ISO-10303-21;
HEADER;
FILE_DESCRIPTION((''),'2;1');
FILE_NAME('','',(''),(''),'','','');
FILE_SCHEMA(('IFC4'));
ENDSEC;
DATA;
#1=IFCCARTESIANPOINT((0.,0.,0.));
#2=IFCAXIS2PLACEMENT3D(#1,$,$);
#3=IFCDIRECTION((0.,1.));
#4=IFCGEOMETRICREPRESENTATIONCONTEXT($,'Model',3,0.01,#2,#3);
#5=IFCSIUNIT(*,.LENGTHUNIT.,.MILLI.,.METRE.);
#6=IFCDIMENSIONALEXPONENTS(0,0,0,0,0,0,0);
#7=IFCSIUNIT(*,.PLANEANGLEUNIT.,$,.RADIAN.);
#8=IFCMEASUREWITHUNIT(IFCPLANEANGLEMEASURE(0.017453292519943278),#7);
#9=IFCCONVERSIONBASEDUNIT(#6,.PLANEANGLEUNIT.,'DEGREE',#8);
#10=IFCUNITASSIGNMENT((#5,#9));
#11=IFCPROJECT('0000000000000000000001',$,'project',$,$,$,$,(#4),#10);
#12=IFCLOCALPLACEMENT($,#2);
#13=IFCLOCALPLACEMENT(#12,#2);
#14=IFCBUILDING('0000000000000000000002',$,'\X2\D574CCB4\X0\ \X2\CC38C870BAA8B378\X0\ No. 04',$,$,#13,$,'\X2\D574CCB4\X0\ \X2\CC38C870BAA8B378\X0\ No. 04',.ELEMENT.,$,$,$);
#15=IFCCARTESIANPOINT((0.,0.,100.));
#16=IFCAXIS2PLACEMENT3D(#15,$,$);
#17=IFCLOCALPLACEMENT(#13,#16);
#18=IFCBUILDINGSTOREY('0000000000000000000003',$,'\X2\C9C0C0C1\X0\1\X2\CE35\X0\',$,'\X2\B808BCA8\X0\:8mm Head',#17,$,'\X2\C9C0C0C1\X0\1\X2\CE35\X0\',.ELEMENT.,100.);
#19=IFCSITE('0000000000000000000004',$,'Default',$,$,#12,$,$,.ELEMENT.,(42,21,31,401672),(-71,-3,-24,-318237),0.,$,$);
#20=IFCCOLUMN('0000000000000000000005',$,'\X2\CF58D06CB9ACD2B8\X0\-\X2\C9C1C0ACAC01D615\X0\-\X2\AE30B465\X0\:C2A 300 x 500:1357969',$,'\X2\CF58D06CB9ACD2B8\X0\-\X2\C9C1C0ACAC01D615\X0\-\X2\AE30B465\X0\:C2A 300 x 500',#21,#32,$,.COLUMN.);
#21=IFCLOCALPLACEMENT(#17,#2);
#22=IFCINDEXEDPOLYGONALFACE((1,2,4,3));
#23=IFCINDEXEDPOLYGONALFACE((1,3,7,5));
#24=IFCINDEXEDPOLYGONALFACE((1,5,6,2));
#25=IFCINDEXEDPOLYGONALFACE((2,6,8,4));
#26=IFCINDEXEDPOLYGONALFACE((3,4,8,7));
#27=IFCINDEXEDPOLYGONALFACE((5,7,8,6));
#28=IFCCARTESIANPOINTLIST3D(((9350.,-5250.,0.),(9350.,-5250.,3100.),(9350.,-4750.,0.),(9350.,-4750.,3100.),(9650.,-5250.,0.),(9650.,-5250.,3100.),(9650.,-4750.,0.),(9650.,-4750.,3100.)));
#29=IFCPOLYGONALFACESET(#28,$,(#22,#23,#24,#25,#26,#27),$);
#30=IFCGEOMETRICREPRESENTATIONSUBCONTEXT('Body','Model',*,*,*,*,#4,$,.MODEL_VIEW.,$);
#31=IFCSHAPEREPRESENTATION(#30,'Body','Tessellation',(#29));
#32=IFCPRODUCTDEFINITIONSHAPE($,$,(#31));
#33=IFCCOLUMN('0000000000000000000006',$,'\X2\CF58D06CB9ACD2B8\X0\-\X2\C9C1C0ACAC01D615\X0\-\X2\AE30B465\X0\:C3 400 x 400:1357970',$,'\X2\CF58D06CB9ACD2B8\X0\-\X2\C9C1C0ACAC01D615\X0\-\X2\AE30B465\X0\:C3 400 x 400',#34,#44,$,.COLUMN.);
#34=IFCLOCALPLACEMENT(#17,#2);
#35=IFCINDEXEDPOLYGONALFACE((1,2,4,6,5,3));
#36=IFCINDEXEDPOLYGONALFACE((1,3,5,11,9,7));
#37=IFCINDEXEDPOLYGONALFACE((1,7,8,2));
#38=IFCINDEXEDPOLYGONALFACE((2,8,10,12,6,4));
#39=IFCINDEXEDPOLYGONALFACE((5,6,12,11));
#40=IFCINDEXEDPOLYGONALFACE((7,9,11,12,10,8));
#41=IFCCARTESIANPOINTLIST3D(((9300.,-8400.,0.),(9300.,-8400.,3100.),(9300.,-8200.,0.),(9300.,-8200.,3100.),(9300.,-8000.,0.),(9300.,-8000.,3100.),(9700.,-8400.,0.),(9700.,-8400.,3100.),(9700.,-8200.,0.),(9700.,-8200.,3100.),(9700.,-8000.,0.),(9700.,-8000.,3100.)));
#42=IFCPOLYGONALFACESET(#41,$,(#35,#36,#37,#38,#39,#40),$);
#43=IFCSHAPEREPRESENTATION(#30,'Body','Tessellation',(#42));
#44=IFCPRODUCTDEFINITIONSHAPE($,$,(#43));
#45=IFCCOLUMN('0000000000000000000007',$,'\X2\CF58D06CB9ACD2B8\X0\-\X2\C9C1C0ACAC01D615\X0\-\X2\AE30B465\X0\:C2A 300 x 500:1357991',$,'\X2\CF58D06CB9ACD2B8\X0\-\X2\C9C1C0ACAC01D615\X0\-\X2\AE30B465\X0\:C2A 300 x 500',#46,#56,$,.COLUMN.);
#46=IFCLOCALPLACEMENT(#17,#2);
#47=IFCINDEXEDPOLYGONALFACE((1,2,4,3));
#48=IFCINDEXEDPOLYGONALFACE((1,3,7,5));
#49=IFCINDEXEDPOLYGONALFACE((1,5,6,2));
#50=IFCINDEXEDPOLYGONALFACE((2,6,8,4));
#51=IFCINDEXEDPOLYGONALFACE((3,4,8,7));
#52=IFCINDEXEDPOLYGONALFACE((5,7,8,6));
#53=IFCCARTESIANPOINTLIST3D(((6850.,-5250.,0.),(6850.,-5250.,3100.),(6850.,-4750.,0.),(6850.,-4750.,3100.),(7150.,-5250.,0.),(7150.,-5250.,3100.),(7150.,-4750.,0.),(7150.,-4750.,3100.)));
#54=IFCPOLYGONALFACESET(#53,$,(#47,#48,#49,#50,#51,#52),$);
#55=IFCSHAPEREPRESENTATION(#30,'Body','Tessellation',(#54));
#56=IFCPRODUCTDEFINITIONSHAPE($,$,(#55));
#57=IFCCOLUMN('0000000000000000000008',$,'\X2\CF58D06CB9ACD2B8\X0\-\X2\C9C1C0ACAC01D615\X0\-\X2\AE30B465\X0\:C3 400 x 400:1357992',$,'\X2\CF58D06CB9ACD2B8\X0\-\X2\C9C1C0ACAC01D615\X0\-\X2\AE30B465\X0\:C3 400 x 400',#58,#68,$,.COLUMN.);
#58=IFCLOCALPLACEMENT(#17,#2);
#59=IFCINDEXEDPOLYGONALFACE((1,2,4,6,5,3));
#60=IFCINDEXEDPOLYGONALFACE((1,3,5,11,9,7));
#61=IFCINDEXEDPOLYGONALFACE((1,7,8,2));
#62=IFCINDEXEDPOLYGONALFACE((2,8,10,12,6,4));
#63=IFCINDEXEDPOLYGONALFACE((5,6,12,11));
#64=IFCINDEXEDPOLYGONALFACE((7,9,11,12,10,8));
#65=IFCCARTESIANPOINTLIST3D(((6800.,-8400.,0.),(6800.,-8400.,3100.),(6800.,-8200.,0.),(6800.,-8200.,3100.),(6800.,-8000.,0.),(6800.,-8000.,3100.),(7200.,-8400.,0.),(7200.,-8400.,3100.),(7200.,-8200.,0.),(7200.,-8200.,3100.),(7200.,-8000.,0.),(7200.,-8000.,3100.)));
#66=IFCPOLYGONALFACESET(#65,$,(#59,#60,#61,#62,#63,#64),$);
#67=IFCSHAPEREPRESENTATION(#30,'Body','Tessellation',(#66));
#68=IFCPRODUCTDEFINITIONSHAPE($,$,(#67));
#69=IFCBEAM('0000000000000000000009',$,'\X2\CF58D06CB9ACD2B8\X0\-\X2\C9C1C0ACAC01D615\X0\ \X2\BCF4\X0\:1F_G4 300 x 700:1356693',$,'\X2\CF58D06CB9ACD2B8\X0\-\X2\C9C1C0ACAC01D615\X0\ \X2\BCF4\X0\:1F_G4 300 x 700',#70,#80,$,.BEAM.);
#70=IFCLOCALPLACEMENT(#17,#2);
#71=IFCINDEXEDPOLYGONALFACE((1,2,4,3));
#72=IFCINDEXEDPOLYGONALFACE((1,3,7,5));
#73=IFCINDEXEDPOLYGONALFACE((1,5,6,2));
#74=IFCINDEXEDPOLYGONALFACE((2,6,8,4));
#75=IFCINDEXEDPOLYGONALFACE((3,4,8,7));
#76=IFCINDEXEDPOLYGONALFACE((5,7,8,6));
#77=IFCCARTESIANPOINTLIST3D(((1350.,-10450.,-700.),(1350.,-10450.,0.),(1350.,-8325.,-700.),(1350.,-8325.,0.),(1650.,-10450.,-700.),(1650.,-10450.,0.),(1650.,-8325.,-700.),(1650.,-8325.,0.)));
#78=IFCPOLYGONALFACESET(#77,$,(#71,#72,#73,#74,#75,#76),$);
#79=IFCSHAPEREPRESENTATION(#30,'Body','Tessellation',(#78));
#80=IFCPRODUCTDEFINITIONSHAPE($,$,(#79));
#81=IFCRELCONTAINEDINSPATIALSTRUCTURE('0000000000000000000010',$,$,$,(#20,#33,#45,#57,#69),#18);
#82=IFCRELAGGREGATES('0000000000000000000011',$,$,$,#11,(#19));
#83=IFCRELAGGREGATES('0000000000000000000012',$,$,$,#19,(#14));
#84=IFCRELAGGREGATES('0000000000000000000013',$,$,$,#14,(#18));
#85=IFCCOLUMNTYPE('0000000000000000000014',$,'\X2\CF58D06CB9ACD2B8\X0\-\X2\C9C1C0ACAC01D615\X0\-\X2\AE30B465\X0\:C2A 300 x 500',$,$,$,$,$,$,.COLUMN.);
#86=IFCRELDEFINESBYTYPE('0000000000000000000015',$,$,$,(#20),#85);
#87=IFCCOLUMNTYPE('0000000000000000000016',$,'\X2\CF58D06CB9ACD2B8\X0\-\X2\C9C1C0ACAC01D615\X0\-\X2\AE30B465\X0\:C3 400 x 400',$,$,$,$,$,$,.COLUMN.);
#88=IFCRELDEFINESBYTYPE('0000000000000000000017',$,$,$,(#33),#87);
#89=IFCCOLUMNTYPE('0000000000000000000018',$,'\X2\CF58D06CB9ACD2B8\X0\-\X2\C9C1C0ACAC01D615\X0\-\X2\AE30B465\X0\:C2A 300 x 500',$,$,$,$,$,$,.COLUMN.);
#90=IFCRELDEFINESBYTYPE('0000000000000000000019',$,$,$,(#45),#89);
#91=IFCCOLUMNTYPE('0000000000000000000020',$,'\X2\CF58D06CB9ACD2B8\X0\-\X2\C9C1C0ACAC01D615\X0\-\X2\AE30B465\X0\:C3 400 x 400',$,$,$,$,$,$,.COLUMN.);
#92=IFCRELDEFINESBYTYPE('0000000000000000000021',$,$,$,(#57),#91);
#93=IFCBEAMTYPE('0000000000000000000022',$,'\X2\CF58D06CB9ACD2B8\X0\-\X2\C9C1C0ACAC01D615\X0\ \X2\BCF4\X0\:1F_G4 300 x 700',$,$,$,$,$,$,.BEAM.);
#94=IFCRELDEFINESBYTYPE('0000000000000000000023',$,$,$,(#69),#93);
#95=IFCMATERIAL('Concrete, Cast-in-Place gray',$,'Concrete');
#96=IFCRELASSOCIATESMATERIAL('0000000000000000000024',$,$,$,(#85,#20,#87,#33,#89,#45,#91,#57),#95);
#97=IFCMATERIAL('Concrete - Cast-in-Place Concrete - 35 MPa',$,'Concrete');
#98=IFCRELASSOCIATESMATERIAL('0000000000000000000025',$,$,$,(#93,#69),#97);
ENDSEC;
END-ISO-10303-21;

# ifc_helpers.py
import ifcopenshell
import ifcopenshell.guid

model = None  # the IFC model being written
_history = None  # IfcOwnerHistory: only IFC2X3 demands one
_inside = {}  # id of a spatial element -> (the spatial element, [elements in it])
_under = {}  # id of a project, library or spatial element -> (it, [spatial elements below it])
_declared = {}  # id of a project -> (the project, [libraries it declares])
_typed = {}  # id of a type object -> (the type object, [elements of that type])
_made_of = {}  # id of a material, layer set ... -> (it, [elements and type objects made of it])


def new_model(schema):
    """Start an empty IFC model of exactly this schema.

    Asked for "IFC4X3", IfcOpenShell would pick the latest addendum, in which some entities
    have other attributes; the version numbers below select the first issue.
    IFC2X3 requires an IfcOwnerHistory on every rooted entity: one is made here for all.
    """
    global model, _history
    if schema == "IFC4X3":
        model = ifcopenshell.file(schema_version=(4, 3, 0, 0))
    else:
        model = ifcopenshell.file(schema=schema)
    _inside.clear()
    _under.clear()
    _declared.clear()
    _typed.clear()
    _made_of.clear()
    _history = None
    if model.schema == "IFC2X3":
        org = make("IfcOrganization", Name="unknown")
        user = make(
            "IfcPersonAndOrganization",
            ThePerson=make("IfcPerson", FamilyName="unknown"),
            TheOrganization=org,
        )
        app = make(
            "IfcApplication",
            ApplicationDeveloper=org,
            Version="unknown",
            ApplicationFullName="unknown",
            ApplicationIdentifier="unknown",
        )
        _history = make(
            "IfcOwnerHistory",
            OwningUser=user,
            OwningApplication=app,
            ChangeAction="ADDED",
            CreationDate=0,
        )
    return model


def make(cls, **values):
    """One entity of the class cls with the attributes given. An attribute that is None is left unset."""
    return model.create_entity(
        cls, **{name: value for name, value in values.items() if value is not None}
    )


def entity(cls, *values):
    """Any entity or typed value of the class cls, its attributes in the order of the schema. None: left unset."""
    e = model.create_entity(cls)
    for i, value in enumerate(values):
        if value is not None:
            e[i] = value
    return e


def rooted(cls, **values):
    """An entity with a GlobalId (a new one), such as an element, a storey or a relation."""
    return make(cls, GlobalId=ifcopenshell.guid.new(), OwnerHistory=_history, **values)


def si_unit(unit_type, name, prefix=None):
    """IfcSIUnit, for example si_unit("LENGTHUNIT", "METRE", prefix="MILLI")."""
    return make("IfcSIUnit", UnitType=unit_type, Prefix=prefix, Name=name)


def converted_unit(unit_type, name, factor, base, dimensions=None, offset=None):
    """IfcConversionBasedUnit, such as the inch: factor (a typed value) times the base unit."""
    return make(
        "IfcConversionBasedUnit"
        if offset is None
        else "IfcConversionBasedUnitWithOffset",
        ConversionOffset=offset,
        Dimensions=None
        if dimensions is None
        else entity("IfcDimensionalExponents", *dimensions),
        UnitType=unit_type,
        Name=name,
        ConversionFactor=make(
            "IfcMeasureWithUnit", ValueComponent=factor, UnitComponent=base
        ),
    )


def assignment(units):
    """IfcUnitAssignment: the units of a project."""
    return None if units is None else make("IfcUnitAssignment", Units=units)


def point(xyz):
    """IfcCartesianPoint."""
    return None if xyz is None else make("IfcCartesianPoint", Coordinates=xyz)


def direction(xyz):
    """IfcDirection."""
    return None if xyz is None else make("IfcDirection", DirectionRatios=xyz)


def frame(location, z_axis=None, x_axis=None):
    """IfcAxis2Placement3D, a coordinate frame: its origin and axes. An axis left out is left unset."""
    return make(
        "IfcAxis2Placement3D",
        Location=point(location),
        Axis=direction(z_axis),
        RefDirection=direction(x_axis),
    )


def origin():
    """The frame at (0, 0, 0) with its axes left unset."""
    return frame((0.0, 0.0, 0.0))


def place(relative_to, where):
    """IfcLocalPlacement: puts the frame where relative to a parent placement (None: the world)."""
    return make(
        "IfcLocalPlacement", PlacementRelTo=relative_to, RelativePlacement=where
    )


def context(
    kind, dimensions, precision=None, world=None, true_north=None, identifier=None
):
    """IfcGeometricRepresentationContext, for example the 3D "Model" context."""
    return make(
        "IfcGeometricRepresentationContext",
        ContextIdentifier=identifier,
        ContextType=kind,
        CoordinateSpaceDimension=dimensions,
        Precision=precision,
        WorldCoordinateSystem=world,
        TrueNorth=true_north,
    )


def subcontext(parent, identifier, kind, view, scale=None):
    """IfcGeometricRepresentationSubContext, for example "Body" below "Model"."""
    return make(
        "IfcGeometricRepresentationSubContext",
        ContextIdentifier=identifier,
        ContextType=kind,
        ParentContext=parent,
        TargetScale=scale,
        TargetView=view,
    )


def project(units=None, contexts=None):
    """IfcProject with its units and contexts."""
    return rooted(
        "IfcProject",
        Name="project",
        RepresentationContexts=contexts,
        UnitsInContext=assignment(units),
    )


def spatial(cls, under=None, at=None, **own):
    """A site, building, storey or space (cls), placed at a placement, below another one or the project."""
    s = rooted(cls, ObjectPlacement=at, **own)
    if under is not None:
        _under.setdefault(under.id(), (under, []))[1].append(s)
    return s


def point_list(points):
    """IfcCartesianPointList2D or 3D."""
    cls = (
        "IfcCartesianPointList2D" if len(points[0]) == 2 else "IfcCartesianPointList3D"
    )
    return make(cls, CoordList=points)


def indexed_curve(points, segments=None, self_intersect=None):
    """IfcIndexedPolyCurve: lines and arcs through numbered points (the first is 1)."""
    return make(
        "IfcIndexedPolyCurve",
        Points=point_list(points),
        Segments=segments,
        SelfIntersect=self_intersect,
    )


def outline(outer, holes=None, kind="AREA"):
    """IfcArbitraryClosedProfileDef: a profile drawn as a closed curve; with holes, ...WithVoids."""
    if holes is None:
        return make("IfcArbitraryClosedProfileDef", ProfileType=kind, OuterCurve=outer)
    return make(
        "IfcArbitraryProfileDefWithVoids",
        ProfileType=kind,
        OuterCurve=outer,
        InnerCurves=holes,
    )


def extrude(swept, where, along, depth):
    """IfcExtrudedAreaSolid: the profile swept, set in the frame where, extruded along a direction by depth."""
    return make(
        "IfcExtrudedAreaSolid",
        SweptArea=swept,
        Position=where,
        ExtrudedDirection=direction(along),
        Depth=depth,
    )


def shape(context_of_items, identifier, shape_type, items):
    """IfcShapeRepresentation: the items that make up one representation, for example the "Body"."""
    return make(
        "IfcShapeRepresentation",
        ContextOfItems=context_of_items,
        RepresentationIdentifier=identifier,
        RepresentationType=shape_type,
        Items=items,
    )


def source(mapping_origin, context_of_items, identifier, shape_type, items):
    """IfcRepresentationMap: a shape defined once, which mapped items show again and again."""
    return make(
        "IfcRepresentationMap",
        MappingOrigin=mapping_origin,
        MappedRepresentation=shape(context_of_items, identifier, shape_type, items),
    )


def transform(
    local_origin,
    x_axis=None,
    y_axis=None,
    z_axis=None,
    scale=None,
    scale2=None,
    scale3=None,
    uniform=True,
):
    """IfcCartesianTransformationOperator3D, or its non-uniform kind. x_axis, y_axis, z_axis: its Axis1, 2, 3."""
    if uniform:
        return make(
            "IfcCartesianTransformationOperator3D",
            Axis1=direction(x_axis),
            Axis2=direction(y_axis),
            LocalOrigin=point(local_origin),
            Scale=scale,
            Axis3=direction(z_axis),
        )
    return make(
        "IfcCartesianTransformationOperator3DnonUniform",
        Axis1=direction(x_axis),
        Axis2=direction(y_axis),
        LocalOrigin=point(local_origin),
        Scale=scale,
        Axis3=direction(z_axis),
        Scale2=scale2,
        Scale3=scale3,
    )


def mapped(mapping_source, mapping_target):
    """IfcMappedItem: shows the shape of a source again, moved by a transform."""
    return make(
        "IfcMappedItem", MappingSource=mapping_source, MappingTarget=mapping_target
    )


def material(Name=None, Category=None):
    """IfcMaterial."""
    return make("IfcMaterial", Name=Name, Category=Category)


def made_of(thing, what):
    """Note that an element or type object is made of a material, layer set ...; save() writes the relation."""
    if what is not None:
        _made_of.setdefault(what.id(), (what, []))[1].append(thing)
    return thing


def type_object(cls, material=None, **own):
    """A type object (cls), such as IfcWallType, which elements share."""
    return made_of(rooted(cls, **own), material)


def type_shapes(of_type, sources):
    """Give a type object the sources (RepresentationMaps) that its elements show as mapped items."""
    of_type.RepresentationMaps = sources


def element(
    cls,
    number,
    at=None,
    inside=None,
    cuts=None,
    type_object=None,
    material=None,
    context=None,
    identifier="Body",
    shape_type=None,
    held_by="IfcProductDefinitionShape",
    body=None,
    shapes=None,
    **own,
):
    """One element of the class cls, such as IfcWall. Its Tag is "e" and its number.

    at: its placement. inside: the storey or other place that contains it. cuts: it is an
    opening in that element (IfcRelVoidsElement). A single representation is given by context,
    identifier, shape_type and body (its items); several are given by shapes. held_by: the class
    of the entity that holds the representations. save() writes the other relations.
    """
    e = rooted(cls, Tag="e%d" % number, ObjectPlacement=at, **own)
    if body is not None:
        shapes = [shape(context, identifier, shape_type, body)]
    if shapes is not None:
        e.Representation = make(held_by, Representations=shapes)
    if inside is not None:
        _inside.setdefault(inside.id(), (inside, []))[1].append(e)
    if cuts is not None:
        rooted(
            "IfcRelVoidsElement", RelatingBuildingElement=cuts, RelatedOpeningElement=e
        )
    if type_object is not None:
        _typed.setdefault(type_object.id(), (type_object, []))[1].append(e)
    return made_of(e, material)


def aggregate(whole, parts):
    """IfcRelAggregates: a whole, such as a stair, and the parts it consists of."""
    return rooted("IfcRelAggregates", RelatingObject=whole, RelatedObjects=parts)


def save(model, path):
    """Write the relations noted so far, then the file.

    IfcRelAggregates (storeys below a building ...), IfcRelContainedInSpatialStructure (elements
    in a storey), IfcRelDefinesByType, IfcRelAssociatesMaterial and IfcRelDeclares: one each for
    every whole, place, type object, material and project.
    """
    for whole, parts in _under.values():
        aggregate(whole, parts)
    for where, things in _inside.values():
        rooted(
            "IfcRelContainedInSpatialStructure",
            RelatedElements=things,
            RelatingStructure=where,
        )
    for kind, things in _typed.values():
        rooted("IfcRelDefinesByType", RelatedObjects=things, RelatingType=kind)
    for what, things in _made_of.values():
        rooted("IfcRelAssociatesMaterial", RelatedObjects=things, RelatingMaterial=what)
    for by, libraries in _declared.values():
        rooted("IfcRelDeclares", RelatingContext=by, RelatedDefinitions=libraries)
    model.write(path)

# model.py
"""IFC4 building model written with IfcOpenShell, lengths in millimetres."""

from ifc_helpers import new_model, entity, si_unit, converted_unit, direction, frame, origin, place, context, subcontext, project, spatial, indexed_curve, outline, extrude, source, transform, mapped, material, type_object, type_shapes, element, save


model = new_model("IFC4")

# Units and contexts
model_context = context("Model", 3, precision=0.01, world=origin(), true_north=direction((0.0, 1.0)))
body_context = subcontext(model_context, "Body", "Model", "MODEL_VIEW")
ifc_project = project(units=[si_unit("LENGTHUNIT", "METRE", prefix="MILLI"), converted_unit("PLANEANGLEUNIT", "DEGREE", entity("IfcPlaneAngleMeasure", 0.017453292519943278), si_unit("PLANEANGLEUNIT", "RADIAN"), dimensions=[0, 0, 0, 0, 0, 0, 0])], contexts=[model_context])

# Site, building, storey
site_placement = place(None, origin())
site = spatial("IfcSite", under=ifc_project, at=site_placement, Name="Default", CompositionType="ELEMENT", RefLatitude=(42, 21, 31, 401672), RefLongitude=(-71, -3, -24, -318237), RefElevation=0.0)
building_placement = place(site_placement, origin())
building = spatial("IfcBuilding", under=site, at=building_placement, Name="해체 참조모델 No. 04", LongName="해체 참조모델 No. 04", CompositionType="ELEMENT")
storey_placement = place(building_placement, frame((0.0, 0.0, 100.0)))
storey = spatial("IfcBuildingStorey", under=building, at=storey_placement, Name="지상1층", ObjectType="레벨:8mm Head", LongName="지상1층", CompositionType="ELEMENT", Elevation=100.0)

# Columns
ifc_material_1 = material(Name="Concrete, Cast-in-Place gray", Category="Concrete")
column_type_1 = type_object("IfcColumnType", Name="콘크리트-직사각형-기둥:C2A 300 x 500", PredefinedType="COLUMN", material=ifc_material_1)
shared_shape_1 = source(origin(), body_context, "Body", "SweptSolid", [
    extrude(outline(indexed_curve([(-150.0, -250.0), (150.0, -250.0), (150.0, 250.0), (-150.0, 250.0), (-150.0, -250.0)], self_intersect=False)), frame((9500.0, -5000.0, 100.0), z_axis=(0.0, 0.0, 1.0), x_axis=(-1.0, 0.0, 0.0)), (0.0, 0.0, 1.0), 3100.0),
])
type_shapes(column_type_1, [shared_shape_1])
column_1_placement = place(storey_placement, frame((0.0, 0.0, -100.0)))
element("IfcColumn", 1, at=column_1_placement, inside=storey, type_object=column_type_1, material=ifc_material_1, Name="콘크리트-직사각형-기둥:C2A 300 x 500:1357969", ObjectType="콘크리트-직사각형-기둥:C2A 300 x 500", PredefinedType="COLUMN", context=body_context, shape_type="MappedRepresentation", body=[
    mapped(shared_shape_1, transform((0.0, 0.0, 0.0), scale=1.0)),
])
column_type_2 = type_object("IfcColumnType", Name="콘크리트-직사각형-기둥:C3 400 x 400", PredefinedType="COLUMN", material=ifc_material_1)
shared_shape_2 = source(origin(), body_context, "Body", "SweptSolid", [
    extrude(outline(indexed_curve([(-200.0, -200.0), (200.0, -200.0), (200.0, 0.0), (200.0, 200.0), (-200.0, 200.0), (-200.0, 0.0), (-200.0, -200.0)], self_intersect=False)), frame((9500.0, -8200.0, 100.0), z_axis=(0.0, 0.0, 1.0), x_axis=(-1.0, 0.0, 0.0)), (0.0, 0.0, 1.0), 3100.0),
])
type_shapes(column_type_2, [shared_shape_2])
column_2_placement = place(storey_placement, frame((0.0, 0.0, -100.0)))
element("IfcColumn", 2, at=column_2_placement, inside=storey, type_object=column_type_2, material=ifc_material_1, Name="콘크리트-직사각형-기둥:C3 400 x 400:1357970", ObjectType="콘크리트-직사각형-기둥:C3 400 x 400", PredefinedType="COLUMN", context=body_context, shape_type="MappedRepresentation", body=[
    mapped(shared_shape_2, transform((0.0, 0.0, 0.0), scale=1.0)),
])
column_type_3 = type_object("IfcColumnType", Name="콘크리트-직사각형-기둥:C2A 300 x 500", PredefinedType="COLUMN", material=ifc_material_1)
shared_shape_3 = source(origin(), body_context, "Body", "SweptSolid", [
    extrude(outline(indexed_curve([(-150.0, -250.0), (150.0, -250.0), (150.0, 250.0), (-150.0, 250.0), (-150.0, -250.0)], self_intersect=False)), frame((7000.0, -5000.0, 100.0), z_axis=(0.0, 0.0, 1.0), x_axis=(-1.0, 0.0, 0.0)), (0.0, 0.0, 1.0), 3100.0),
])
type_shapes(column_type_3, [shared_shape_3])
column_3_placement = place(storey_placement, frame((0.0, 0.0, -100.0)))
element("IfcColumn", 3, at=column_3_placement, inside=storey, type_object=column_type_3, material=ifc_material_1, Name="콘크리트-직사각형-기둥:C2A 300 x 500:1357991", ObjectType="콘크리트-직사각형-기둥:C2A 300 x 500", PredefinedType="COLUMN", context=body_context, shape_type="MappedRepresentation", body=[
    mapped(shared_shape_3, transform((0.0, 0.0, 0.0), scale=1.0)),
])
column_type_4 = type_object("IfcColumnType", Name="콘크리트-직사각형-기둥:C3 400 x 400", PredefinedType="COLUMN", material=ifc_material_1)
shared_shape_4 = source(origin(), body_context, "Body", "SweptSolid", [
    extrude(outline(indexed_curve([(-200.0, -200.0), (200.0, -200.0), (200.0, 0.0), (200.0, 200.0), (-200.0, 200.0), (-200.0, 0.0), (-200.0, -200.0)], self_intersect=False)), frame((7000.0, -8200.0, 100.0), z_axis=(0.0, 0.0, 1.0), x_axis=(-1.0, 0.0, 0.0)), (0.0, 0.0, 1.0), 3100.0),
])
type_shapes(column_type_4, [shared_shape_4])
column_4_placement = place(storey_placement, frame((0.0, 0.0, -100.0)))
element("IfcColumn", 4, at=column_4_placement, inside=storey, type_object=column_type_4, material=ifc_material_1, Name="콘크리트-직사각형-기둥:C3 400 x 400:1357992", ObjectType="콘크리트-직사각형-기둥:C3 400 x 400", PredefinedType="COLUMN", context=body_context, shape_type="MappedRepresentation", body=[
    mapped(shared_shape_4, transform((0.0, 0.0, 0.0), scale=1.0)),
])

# Beam
ifc_material_2 = material(Name="Concrete - Cast-in-Place Concrete - 35 MPa", Category="Concrete")
beam_type = type_object("IfcBeamType", Name="콘크리트-직사각형 보:1F_G4 300 x 700", PredefinedType="BEAM", material=ifc_material_2)
shared_shape_5 = source(origin(), body_context, "Body", "SweptSolid", [
    extrude(outline(indexed_curve([(-150.0, -350.0), (150.0, -350.0), (150.0, 350.0), (-150.0, 350.0), (-150.0, -350.0)], self_intersect=False)), frame((1500.0, -10450.0, -250.0), z_axis=(0.0, 1.0, 0.0), x_axis=(-1.0, 0.0, 0.0)), (0.0, 0.0, 1.0), 2125.0),
])
type_shapes(beam_type, [shared_shape_5])
beam_placement = place(storey_placement, frame((0.0, 0.0, -100.0)))
element("IfcBeam", 5, at=beam_placement, inside=storey, type_object=beam_type, material=ifc_material_2, Name="콘크리트-직사각형 보:1F_G4 300 x 700:1356693", ObjectType="콘크리트-직사각형 보:1F_G4 300 x 700", PredefinedType="BEAM", context=body_context, shape_type="MappedRepresentation", body=[
    mapped(shared_shape_5, transform((0.0, 0.0, 0.0), scale=1.0)),
])

save(model, "model.ifc")
